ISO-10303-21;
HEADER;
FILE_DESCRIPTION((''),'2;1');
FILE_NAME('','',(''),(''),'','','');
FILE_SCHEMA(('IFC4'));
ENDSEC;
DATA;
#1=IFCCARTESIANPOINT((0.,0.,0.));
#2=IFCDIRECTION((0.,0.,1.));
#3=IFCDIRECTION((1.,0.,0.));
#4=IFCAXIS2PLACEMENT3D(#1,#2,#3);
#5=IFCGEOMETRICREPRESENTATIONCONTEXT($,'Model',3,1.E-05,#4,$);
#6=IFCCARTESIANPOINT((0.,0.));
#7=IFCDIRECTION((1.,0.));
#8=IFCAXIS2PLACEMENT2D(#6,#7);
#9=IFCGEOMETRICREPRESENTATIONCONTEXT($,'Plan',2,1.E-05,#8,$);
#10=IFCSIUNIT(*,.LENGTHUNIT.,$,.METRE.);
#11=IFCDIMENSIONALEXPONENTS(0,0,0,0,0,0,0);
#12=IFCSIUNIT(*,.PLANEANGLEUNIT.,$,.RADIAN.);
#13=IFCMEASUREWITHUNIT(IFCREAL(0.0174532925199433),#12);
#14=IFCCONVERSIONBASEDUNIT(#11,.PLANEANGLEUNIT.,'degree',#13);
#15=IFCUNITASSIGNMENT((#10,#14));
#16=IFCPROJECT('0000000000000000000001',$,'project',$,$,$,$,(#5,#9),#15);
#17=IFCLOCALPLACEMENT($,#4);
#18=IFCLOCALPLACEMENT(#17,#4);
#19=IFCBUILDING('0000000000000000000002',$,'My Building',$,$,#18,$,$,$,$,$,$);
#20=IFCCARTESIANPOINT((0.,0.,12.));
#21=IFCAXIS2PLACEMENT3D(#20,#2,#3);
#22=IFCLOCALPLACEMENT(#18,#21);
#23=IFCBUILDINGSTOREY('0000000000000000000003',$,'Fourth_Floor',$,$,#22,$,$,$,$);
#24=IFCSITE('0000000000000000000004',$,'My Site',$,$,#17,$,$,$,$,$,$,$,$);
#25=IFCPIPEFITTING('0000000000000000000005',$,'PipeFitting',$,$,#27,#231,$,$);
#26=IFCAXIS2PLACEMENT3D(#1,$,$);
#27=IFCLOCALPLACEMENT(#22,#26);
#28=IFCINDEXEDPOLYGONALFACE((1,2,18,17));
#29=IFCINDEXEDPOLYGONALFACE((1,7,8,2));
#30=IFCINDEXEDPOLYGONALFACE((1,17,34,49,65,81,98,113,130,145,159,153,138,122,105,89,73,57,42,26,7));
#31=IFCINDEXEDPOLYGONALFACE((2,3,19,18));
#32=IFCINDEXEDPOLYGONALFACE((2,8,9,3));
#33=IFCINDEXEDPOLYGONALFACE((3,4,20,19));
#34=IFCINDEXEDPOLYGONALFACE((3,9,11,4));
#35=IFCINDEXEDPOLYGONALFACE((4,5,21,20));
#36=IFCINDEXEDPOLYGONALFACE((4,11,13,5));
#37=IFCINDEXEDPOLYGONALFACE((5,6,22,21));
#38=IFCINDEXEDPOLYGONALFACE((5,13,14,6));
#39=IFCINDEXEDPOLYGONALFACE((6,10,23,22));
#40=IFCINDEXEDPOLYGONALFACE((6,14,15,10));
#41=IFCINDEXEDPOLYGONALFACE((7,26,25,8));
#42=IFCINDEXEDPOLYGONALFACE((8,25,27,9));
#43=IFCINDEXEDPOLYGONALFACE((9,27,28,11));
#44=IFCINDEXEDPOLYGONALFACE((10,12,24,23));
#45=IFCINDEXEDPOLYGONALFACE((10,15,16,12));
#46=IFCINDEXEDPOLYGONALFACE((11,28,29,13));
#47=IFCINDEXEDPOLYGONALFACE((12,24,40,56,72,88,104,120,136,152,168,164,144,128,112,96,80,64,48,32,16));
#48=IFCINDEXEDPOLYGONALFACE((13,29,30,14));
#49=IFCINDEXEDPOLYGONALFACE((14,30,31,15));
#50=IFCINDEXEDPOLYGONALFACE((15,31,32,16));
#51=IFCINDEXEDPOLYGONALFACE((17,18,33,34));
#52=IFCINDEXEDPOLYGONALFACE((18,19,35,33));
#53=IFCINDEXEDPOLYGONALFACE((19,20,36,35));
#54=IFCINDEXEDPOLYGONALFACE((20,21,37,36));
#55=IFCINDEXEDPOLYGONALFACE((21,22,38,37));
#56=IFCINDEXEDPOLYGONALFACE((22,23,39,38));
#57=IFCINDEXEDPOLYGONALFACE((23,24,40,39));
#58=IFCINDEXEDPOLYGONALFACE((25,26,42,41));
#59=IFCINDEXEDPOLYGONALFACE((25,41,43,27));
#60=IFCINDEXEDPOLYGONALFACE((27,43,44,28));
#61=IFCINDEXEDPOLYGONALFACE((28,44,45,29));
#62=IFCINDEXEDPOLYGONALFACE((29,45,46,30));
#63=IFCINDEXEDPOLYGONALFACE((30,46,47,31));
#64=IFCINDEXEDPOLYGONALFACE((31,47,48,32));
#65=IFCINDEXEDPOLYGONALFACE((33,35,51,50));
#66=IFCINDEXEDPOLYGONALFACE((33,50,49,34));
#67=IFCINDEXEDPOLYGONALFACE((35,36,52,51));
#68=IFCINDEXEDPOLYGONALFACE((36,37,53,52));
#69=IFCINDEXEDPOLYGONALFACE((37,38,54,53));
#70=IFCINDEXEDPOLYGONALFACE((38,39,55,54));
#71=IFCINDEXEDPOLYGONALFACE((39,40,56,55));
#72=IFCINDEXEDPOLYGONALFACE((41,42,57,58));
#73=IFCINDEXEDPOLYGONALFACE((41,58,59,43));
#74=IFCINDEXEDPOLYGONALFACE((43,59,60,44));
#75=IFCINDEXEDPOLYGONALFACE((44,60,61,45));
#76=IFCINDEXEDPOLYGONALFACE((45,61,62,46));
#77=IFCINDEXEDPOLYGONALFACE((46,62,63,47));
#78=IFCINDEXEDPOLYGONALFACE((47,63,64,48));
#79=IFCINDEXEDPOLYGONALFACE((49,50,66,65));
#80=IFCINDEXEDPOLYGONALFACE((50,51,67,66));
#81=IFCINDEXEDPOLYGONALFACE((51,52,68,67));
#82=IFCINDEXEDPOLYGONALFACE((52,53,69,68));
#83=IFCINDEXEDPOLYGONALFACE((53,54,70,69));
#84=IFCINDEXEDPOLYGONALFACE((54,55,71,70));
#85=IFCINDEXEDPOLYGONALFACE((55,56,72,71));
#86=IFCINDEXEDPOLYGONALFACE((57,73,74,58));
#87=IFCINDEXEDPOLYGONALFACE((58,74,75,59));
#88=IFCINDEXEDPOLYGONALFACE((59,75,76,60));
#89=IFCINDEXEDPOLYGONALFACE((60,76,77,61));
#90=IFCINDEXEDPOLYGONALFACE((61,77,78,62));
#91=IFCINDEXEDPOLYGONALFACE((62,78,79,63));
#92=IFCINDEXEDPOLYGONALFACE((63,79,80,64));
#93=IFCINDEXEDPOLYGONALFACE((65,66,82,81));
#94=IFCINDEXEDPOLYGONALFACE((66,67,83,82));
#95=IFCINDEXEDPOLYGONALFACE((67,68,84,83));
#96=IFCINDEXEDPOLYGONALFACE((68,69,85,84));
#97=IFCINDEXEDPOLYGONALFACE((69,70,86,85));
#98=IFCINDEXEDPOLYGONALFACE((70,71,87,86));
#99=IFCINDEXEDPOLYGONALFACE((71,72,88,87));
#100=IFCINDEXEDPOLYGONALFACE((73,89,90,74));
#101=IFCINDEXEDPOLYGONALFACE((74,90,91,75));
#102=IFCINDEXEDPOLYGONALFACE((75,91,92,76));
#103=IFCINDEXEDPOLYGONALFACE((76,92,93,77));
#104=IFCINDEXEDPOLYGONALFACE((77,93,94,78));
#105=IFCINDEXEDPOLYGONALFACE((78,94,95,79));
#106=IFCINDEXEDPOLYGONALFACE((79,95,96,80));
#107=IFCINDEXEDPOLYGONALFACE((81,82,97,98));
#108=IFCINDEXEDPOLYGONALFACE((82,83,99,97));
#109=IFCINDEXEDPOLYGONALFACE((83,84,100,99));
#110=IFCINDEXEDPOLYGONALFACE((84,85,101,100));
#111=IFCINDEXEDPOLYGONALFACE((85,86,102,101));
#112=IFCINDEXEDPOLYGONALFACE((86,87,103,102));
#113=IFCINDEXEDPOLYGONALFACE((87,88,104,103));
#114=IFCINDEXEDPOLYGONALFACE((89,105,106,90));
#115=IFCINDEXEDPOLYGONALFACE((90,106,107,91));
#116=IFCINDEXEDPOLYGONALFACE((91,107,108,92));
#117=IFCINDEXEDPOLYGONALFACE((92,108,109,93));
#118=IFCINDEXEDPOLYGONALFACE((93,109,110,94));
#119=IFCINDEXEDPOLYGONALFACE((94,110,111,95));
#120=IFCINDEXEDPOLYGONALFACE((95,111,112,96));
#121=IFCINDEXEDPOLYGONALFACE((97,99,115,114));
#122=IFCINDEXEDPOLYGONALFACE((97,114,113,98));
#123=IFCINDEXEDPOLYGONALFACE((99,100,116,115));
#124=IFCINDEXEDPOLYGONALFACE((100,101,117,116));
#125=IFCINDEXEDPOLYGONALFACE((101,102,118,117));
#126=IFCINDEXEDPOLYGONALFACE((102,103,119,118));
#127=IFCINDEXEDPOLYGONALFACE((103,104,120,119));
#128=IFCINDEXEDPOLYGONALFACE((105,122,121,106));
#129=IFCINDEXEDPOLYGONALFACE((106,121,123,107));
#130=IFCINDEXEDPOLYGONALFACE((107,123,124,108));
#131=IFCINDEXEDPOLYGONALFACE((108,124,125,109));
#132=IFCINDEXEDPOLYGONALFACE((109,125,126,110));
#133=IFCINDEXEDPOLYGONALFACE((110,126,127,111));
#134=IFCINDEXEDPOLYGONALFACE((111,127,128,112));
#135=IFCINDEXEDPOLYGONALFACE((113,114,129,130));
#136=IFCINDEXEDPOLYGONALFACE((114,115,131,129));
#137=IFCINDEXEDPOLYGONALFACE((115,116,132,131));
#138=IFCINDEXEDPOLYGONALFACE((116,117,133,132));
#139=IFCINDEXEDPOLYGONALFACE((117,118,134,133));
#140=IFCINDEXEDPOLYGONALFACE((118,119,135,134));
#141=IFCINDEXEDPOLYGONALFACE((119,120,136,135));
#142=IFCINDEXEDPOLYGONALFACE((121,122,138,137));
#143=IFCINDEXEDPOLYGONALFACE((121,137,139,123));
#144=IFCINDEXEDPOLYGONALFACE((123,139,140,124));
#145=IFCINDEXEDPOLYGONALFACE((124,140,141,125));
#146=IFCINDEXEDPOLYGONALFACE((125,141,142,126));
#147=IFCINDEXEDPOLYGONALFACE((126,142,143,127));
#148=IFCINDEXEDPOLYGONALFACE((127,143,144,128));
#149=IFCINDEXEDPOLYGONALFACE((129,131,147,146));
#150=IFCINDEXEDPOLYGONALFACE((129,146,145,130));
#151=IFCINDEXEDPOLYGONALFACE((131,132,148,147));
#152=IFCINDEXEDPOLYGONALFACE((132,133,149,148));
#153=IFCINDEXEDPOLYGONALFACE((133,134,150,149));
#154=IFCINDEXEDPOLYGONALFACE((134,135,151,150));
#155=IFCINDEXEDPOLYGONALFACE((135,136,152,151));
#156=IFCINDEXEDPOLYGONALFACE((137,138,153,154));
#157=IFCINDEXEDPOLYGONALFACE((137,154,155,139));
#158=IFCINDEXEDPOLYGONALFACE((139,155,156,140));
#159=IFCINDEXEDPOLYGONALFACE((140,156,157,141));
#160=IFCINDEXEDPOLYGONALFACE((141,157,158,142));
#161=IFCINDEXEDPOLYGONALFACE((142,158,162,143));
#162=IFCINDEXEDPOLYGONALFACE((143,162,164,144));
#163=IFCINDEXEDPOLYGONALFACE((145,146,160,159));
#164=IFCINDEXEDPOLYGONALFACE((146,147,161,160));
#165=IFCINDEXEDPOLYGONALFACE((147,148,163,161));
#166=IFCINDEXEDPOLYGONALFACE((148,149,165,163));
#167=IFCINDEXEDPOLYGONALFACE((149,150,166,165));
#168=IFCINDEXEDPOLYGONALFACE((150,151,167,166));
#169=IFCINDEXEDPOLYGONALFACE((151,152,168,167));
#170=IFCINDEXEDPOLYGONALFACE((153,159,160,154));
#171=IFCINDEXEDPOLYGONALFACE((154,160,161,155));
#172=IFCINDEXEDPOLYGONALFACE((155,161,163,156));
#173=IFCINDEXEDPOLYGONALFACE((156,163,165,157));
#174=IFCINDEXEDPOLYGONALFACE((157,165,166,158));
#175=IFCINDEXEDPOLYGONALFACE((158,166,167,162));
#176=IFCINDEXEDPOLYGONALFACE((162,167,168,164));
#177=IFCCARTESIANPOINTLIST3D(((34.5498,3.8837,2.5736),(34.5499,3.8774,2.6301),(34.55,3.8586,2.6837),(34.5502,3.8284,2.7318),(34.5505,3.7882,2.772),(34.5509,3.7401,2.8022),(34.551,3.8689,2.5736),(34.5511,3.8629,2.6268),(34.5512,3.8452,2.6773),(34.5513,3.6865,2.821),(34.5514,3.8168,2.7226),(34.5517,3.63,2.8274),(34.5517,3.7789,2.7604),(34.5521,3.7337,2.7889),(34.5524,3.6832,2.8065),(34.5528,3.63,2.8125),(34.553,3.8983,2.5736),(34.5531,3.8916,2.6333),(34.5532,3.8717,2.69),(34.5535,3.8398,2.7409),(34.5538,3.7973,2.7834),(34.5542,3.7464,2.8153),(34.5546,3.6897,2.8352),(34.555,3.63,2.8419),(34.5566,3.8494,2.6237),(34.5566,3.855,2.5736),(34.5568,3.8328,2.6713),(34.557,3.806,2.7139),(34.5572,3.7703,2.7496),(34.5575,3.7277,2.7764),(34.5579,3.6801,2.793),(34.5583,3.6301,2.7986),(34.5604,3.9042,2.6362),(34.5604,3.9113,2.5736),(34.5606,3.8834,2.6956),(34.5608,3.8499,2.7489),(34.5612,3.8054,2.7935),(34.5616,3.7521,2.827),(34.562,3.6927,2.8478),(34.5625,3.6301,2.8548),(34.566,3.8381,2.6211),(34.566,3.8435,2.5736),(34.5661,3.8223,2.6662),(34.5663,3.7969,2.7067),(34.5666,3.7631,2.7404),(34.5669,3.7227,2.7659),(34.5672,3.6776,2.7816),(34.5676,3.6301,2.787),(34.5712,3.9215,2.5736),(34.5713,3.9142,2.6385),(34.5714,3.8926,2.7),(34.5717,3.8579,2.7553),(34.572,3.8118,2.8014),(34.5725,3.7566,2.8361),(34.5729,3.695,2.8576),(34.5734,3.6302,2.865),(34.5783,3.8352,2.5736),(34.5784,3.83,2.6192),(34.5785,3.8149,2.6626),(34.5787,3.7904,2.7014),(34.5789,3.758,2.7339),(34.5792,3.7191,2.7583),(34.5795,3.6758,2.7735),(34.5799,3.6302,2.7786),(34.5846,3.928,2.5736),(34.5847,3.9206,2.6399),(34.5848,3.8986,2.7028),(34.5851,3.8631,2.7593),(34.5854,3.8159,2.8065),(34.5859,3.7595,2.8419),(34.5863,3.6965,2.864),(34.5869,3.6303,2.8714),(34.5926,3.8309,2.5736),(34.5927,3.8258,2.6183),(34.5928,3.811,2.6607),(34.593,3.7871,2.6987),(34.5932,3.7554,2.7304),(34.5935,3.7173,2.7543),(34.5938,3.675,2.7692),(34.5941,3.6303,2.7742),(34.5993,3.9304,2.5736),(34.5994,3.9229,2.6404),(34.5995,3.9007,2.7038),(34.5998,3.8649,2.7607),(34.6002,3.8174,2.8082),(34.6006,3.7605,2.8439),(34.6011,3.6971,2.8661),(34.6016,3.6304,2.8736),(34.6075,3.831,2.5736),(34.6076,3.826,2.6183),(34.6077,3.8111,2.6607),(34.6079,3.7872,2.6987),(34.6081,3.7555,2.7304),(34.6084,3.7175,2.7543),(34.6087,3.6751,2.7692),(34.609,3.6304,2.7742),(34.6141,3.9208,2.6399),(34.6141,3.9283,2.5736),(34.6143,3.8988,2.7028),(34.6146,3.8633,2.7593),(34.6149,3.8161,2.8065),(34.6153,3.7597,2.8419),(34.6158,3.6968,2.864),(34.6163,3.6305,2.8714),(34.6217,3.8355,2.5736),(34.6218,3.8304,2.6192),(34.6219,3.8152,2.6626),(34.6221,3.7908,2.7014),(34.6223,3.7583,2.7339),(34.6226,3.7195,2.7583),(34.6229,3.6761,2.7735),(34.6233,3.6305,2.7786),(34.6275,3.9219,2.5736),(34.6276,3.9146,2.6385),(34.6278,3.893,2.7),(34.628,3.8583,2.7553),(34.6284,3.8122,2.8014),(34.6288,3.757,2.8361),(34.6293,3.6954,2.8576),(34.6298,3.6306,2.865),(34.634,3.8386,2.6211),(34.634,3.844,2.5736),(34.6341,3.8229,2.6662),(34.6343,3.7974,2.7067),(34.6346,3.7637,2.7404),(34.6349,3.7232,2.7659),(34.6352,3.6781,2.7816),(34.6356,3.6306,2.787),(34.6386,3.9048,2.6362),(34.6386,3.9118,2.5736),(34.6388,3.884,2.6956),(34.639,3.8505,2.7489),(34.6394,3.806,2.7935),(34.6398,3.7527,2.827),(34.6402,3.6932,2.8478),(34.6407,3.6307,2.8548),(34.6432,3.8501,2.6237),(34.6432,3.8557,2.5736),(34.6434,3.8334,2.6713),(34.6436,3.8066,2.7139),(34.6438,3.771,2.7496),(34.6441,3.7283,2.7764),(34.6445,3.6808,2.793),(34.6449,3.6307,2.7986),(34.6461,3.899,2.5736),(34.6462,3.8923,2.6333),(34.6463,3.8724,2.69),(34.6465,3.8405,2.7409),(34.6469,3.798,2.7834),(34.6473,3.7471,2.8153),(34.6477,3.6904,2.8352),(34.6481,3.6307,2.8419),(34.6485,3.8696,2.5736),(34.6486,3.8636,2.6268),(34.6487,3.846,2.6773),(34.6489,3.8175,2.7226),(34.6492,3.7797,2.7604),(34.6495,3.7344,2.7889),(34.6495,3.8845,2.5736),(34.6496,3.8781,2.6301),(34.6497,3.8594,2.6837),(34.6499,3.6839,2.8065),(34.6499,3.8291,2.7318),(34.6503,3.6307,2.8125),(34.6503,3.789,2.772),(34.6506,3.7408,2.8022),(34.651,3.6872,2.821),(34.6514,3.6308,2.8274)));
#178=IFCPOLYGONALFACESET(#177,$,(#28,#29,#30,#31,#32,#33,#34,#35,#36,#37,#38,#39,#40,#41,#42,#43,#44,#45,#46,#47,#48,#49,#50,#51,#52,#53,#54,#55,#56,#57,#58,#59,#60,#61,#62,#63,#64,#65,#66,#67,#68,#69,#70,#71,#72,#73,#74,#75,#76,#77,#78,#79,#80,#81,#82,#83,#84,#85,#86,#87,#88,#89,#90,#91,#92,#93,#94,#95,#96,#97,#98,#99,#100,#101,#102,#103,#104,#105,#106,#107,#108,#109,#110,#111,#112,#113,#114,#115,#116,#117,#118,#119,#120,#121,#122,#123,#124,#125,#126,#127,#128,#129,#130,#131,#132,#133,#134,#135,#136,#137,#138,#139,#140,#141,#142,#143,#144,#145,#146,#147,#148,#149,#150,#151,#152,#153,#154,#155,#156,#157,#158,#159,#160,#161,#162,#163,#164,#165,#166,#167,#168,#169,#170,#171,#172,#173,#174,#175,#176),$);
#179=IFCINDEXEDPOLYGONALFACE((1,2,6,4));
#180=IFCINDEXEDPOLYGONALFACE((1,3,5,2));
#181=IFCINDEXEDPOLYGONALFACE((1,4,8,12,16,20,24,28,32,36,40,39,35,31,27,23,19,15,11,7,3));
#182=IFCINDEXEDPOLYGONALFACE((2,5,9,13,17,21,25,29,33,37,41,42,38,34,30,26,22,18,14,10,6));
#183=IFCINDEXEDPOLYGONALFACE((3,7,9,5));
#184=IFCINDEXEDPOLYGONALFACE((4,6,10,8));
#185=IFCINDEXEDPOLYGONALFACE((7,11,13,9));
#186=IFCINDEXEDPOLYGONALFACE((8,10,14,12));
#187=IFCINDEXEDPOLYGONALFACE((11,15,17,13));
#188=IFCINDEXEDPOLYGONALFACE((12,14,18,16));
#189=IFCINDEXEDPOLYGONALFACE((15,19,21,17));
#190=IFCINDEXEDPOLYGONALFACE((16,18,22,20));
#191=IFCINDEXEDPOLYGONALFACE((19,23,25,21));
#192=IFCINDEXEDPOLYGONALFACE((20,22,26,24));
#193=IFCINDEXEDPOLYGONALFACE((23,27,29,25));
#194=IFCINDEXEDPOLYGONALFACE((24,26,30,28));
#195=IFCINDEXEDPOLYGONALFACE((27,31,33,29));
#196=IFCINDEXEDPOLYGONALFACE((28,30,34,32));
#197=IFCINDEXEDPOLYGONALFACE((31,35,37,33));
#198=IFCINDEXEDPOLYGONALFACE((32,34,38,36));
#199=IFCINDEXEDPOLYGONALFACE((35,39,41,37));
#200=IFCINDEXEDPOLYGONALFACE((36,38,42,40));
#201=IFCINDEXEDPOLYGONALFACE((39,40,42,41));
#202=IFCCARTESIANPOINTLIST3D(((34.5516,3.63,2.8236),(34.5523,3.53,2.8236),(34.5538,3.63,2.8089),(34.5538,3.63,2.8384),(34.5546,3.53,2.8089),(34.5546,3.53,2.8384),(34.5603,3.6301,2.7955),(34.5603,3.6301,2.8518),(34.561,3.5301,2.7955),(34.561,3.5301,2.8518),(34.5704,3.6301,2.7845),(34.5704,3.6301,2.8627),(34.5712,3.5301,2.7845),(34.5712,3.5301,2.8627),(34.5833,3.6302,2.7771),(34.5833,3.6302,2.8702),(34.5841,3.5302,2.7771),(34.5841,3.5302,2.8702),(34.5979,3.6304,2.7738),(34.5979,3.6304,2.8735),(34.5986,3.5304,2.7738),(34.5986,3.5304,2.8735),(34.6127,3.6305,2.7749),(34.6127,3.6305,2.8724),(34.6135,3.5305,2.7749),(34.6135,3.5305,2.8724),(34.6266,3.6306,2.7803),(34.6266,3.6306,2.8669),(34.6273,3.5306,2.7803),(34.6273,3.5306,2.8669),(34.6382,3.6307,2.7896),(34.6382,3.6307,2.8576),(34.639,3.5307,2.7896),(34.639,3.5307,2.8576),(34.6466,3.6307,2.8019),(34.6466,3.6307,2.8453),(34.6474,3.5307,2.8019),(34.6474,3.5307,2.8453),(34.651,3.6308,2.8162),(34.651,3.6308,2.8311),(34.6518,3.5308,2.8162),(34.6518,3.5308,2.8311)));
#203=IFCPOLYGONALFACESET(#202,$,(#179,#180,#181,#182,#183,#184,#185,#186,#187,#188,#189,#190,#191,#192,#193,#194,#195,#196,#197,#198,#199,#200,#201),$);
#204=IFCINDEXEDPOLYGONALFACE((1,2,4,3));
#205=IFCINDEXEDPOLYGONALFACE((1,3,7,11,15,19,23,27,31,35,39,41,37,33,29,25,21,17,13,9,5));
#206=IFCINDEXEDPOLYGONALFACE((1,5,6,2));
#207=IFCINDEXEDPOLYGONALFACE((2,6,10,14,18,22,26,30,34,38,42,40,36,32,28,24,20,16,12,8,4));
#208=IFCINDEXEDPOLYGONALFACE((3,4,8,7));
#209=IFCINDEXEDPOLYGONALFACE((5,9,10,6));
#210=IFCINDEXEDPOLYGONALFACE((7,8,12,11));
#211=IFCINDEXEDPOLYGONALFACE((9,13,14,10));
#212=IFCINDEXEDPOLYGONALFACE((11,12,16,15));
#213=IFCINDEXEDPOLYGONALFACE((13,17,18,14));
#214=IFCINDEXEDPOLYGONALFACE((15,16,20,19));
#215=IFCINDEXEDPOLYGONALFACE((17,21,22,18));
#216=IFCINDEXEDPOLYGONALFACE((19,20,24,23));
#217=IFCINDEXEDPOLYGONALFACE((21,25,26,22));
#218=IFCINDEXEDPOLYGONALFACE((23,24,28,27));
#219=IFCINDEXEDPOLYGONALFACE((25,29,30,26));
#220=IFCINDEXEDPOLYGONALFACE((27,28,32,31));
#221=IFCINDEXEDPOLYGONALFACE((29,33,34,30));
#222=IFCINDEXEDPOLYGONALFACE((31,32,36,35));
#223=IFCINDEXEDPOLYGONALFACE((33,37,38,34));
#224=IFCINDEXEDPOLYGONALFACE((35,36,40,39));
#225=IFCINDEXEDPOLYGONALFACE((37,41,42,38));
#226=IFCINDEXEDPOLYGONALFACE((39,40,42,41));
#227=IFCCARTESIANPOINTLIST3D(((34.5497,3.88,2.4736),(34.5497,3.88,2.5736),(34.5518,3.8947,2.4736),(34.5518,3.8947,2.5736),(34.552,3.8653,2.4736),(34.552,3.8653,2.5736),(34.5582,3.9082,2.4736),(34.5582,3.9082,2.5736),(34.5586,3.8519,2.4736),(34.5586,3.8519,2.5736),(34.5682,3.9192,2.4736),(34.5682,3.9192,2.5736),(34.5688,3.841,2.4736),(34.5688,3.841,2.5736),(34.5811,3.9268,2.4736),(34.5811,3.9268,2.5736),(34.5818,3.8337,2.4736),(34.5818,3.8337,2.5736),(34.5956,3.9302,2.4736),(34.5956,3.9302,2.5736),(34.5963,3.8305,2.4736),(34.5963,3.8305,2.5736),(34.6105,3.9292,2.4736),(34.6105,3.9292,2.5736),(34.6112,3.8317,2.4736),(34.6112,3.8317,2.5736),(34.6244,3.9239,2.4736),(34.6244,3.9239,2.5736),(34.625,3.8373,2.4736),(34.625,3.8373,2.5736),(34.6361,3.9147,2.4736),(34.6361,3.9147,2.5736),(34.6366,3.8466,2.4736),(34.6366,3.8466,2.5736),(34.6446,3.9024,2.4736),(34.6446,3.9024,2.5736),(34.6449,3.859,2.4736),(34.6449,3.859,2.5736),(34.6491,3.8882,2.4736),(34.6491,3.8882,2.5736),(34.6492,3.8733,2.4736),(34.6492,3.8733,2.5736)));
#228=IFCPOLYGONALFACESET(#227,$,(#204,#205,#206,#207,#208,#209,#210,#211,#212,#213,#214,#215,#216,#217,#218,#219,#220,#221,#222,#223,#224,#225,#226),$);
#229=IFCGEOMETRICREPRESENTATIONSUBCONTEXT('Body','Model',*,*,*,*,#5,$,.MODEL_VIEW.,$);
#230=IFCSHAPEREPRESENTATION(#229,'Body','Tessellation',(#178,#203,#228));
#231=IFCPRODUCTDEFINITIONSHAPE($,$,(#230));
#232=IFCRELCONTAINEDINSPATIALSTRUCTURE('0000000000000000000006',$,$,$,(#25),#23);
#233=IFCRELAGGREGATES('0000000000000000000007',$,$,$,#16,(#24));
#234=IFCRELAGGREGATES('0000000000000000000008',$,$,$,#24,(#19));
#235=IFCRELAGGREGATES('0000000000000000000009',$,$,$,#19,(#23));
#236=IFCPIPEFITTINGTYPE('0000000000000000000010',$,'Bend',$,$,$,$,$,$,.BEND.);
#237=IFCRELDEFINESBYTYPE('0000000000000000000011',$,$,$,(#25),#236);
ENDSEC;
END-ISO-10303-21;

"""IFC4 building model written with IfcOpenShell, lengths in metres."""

from ifc_helpers import new_model, entity, si_unit, converted_unit, frame, origin_with_axes, origin_2d_with_axis, place, context, subcontext, project, spatial, circle, extrude, source, transform, mapped, type_object, type_shapes, element, save


model = new_model("IFC4")

# Units and contexts
model_context = context("Model", 3, precision=1e-05, world=origin_with_axes())
plan_context = context("Plan", 2, precision=1e-05, world=origin_2d_with_axis())
body_context_1 = subcontext(model_context, "Body", "Model", "MODEL_VIEW")
ifc_project = project(units=[si_unit("LENGTHUNIT", "METRE"), converted_unit("PLANEANGLEUNIT", "degree", entity("IfcReal", 0.0174532925199433), si_unit("PLANEANGLEUNIT", "RADIAN"), dimensions=[0, 0, 0, 0, 0, 0, 0])], contexts=[model_context, plan_context])

# Site, building, storey
site_placement = place(None, origin_with_axes())
site = spatial("IfcSite", under=ifc_project, at=site_placement, Name="My Site")
building_placement = place(site_placement, origin_with_axes())
building = spatial("IfcBuilding", under=site, at=building_placement, Name="My Building")
storey_placement = place(building_placement, frame((0.0, 0.0, 12.0), z_axis=(0.0, 0.0, 1.0), x_axis=(1.0, 0.0, 0.0)))
storey = spatial("IfcBuildingStorey", under=building, at=storey_placement, Name="Fourth_Floor")

# Pipe fitting
pipe_fitting_type = type_object("IfcPipeFittingType", Name="Bend", PredefinedType="BEND")
shared_shape_1 = source(origin_with_axes(), body_context_1, "Body", "SolidModel", [
    entity("IfcSweptDiskSolid", entity("IfcIndexedPolyCurve", entity("IfcCartesianPointList3D", [[0.0, 0.0, -0.1], [0.0, 0.0732, -0.2768], [0.0, 0.25, -0.35]]), [entity("IfcArcIndex", [1, 2, 3])]), 0.05),
    extrude(circle(Radius=0.05), origin_with_axes(), (0.0, 0.0, -1.0), 0.1),
    extrude(circle(Radius=0.05), frame((0.0, 0.25, -0.35), z_axis=(0.0, 1.0, 0.0), x_axis=(1.0, 0.0, 0.0)), (0.0, 0.0, 1.0), 0.1),
])
type_shapes(pipe_fitting_type, [shared_shape_1])
for number, where, z_axis, x_axis, name in (
    (1, (34.6023, 3.5304, 2.8236), (0.007564, -0.999971, 0.0), (-0.999971, -0.007564, 0.0), "PipeFitting"),
):
    element("IfcPipeFitting", number, at=place(storey_placement, frame(where, z_axis=z_axis, x_axis=x_axis)), inside=storey, type_object=pipe_fitting_type, Name=name, context=body_context_1, shape_type="MappedRepresentation", body=[
        mapped(shared_shape_1, transform((0.0, 0.0, 0.0), x_axis=(1.0, 0.0, 0.0), y_axis=(0.0, 1.0, 0.0), z_axis=(0.0, 0.0, 1.0), scale=1.0)),
    ])

save(model, "model.ifc")
